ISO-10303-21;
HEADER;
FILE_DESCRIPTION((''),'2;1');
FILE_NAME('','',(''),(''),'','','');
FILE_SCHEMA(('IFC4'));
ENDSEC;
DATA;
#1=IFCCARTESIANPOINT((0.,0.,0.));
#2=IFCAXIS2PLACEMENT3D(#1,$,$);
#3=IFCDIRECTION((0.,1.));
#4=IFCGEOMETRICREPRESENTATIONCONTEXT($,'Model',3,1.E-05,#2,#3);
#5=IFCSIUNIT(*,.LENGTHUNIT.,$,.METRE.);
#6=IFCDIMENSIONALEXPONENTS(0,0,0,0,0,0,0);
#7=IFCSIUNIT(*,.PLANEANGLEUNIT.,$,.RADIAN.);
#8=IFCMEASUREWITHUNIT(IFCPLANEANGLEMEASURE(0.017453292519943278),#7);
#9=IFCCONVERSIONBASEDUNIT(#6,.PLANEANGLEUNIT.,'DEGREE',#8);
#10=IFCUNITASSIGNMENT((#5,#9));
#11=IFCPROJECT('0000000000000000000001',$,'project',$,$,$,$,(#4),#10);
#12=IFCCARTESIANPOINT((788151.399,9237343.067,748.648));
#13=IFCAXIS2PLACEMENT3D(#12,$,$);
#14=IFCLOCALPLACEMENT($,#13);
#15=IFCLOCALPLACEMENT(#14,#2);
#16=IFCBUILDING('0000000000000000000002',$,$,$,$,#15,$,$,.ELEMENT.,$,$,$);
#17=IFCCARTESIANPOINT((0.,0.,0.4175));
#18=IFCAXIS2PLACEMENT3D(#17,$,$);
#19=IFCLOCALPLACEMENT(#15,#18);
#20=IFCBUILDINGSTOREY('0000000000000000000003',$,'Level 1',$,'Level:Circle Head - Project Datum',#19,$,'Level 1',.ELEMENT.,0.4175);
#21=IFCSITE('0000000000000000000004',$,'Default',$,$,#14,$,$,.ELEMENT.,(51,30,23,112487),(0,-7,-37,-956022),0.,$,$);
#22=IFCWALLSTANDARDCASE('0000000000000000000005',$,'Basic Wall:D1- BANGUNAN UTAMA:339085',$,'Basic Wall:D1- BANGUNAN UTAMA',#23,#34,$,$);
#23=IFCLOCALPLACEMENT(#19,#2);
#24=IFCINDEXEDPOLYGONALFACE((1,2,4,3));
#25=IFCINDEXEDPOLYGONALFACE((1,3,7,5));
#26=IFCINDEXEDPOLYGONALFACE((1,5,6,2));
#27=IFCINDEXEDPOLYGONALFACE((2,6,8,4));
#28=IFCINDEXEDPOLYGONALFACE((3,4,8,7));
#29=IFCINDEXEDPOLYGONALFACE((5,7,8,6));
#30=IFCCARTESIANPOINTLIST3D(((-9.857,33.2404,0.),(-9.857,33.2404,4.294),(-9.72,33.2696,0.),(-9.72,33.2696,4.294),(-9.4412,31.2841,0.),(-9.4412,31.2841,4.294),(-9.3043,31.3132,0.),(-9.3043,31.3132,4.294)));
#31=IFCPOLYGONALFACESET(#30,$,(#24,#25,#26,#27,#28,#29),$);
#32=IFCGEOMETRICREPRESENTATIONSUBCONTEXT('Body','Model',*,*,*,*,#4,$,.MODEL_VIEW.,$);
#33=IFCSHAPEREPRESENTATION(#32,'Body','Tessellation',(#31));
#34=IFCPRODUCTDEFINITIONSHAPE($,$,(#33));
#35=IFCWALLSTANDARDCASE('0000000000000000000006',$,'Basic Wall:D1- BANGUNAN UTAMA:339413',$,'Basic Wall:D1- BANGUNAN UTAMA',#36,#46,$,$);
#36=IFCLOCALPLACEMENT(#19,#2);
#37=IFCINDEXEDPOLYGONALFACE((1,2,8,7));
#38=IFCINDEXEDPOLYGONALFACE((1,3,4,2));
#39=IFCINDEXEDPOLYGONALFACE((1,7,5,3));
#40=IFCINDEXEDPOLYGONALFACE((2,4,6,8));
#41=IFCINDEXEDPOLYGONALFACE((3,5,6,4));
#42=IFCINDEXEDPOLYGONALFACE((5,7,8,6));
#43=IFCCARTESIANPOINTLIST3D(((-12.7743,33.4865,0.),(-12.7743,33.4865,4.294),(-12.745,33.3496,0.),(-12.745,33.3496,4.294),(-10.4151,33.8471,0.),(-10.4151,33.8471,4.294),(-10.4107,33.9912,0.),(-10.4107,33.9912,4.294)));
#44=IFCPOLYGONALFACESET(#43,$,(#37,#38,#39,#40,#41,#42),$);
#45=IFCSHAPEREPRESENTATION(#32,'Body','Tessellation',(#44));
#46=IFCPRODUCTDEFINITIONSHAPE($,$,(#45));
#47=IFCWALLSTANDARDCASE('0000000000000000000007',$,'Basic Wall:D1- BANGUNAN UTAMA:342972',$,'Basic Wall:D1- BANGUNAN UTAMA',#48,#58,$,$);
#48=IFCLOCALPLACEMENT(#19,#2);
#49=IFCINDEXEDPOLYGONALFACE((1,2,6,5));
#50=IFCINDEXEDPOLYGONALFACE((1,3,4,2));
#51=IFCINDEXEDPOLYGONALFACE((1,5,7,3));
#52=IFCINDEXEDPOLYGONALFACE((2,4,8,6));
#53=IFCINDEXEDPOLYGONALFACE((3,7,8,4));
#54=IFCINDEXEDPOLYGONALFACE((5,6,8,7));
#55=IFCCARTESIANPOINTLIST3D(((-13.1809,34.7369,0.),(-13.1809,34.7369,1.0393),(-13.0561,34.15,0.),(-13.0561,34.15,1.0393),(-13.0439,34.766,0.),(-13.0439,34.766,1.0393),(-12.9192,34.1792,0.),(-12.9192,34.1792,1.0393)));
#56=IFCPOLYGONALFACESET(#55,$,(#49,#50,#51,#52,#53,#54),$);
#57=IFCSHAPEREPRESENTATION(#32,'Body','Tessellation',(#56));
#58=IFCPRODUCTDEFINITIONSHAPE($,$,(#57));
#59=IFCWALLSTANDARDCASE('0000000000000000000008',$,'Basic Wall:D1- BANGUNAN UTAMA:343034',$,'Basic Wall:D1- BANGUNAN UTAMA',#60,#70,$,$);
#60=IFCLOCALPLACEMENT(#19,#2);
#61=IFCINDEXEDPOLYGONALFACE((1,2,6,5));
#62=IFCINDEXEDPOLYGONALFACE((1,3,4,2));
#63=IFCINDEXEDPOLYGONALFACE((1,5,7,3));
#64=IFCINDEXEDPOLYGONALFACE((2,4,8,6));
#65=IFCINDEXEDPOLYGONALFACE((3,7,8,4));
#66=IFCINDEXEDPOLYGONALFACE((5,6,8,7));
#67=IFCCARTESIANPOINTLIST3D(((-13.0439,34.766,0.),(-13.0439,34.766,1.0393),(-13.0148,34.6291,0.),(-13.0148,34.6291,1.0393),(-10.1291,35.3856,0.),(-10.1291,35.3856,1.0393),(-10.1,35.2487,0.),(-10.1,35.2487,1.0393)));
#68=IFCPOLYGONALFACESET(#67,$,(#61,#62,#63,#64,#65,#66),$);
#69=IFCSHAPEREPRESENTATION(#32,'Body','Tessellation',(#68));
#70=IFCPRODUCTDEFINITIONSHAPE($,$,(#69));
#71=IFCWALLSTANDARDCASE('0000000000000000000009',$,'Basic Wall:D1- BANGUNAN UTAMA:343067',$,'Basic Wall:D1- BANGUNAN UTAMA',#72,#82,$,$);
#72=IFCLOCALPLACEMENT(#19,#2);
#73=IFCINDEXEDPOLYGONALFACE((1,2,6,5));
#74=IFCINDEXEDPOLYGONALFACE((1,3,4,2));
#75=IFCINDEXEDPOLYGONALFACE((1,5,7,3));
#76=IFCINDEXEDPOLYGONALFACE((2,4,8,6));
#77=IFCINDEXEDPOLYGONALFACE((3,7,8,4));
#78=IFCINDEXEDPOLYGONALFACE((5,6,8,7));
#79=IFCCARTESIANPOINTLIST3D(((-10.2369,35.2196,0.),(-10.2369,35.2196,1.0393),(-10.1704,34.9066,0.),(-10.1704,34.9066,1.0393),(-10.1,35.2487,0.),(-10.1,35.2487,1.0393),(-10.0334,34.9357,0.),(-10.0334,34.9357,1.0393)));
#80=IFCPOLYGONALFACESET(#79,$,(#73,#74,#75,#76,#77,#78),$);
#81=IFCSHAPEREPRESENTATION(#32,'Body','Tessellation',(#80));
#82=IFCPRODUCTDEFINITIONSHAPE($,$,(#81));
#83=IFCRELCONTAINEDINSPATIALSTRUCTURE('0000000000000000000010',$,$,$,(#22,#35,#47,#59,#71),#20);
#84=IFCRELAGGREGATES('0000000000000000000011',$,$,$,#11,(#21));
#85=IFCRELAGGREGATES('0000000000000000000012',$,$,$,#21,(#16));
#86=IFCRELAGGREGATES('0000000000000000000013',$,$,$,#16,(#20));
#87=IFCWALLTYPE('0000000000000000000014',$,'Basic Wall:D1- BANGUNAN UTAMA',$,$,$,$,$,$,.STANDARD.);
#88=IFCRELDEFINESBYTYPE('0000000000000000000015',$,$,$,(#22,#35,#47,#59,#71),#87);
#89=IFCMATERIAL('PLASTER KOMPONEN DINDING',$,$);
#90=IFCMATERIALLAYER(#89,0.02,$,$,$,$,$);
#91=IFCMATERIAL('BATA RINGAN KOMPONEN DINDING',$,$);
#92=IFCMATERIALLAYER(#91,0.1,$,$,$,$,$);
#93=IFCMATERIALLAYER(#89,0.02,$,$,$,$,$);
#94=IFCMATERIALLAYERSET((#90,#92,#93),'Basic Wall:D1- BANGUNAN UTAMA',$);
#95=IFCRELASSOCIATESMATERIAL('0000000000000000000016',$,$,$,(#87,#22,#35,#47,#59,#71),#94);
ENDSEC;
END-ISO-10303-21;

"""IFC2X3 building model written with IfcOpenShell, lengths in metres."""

from ifc_helpers import new_model, entity, si_unit, converted_unit, direction, frame, frame_2d, origin, place, context, subcontext, project, spatial, polyline, rectangle, outline, extrude, material, layer, layer_set, layer_usage, type_object, element, save


model = new_model("IFC2X3")

# Units and contexts
model_context = context("Model", 3, precision=1e-05, world=origin(), true_north=direction((0.0, 1.0)))
body_context = subcontext(model_context, "Body", "Model", "MODEL_VIEW")
ifc_project = project(units=[si_unit("LENGTHUNIT", "METRE"), converted_unit("PLANEANGLEUNIT", "DEGREE", entity("IfcPlaneAngleMeasure", 0.017453292519943278), si_unit("PLANEANGLEUNIT", "RADIAN"), dimensions=[0, 0, 0, 0, 0, 0, 0])], contexts=[model_context])

# Site, building, storey
site_placement = place(None, frame((788151.399, 9237343.067, 748.648)))
site = spatial("IfcSite", under=ifc_project, at=site_placement, Name="Default", CompositionType="ELEMENT", RefLatitude=(51, 30, 23, 112487), RefLongitude=(0, -7, -37, -956022), RefElevation=0.0)
building_placement = place(site_placement, origin())
building = spatial("IfcBuilding", under=site, at=building_placement, CompositionType="ELEMENT")
storey_placement = place(building_placement, frame((0.0, 0.0, 0.4175)))
storey = spatial("IfcBuildingStorey", under=building, at=storey_placement, Name="Level 1", ObjectType="Level:Circle Head - Project Datum", LongName="Level 1", CompositionType="ELEMENT", Elevation=0.4175)

# Walls
ifc_material_1 = material(Name="PLASTER KOMPONEN DINDING")
ifc_layer_1 = layer(ifc_material_1, 0.02)
ifc_material_2 = material(Name="BATA RINGAN KOMPONEN DINDING")
ifc_layer_2 = layer(ifc_material_2, 0.1)
ifc_layer_3 = layer(ifc_material_1, 0.02)
ifc_layer_set = layer_set([ifc_layer_1, ifc_layer_2, ifc_layer_3], Name="Basic Wall:D1- BANGUNAN UTAMA")
wall_type = type_object("IfcWallType", Name="Basic Wall:D1- BANGUNAN UTAMA", PredefinedType="STANDARD", material=ifc_layer_set)
ifc_layer_usage_1 = layer_usage(ifc_layer_set, "AXIS2", "NEGATIVE", 0.07)
wall_1_placement = place(storey_placement, frame((-9.7885, 33.255, 0.0), z_axis=(0.0, 0.0, 1.0), x_axis=(0.207863, -0.978158, 0.0)))
element("IfcWallStandardCase", 1, at=wall_1_placement, inside=storey, type_object=wall_type, material=ifc_layer_usage_1, Name="Basic Wall:D1- BANGUNAN UTAMA:339085", ObjectType="Basic Wall:D1- BANGUNAN UTAMA", context=body_context, shape_type="SweptSolid", body=[
    extrude(rectangle(XDim=2.0, YDim=0.14, at=frame_2d((1.0, 0.0), x_axis=(-1.0, 0.0))), origin(), (0.0, 0.0, 1.0), 4.294),
])
ifc_layer_usage_2 = layer_usage(ifc_layer_set, "AXIS2", "NEGATIVE", 0.07)
wall_2_placement = place(storey_placement, frame((-12.7597, 33.418, 0.0), z_axis=(0.0, 0.0, 1.0), x_axis=(0.977952, 0.208828, 0.0)))
element("IfcWallStandardCase", 2, at=wall_2_placement, inside=storey, type_object=wall_type, material=ifc_layer_usage_2, Name="Basic Wall:D1- BANGUNAN UTAMA:339413", ObjectType="Basic Wall:D1- BANGUNAN UTAMA", context=body_context, shape_type="SweptSolid", body=[
    extrude(outline(polyline([(2.3824, -0.07), (2.4169, 0.07), (0.0, 0.07), (0.0, -0.07), (2.3824, -0.07)])), origin(), (0.0, 0.0, 1.0), 4.294),
])
ifc_layer_usage_3 = layer_usage(ifc_layer_set, "AXIS2", "NEGATIVE", 0.07)
wall_3_placement = place(storey_placement, frame((-12.9877, 34.1646, 0.0), z_axis=(0.0, 0.0, 1.0), x_axis=(-0.207912, 0.978148, 0.0)))
element("IfcWallStandardCase", 3, at=wall_3_placement, inside=storey, type_object=wall_type, material=ifc_layer_usage_3, Name="Basic Wall:D1- BANGUNAN UTAMA:342972", ObjectType="Basic Wall:D1- BANGUNAN UTAMA", context=body_context, shape_type="SweptSolid", body=[
    extrude(rectangle(XDim=0.6, YDim=0.14, at=frame_2d((0.3, 0.0), x_axis=(-1.0, 0.0))), origin(), (0.0, 0.0, 1.0), 1.0393),
])
ifc_layer_usage_4 = layer_usage(ifc_layer_set, "AXIS2", "NEGATIVE", 0.07)
wall_4_placement = place(storey_placement, frame((-13.0294, 34.6976, 0.0), z_axis=(0.0, 0.0, 1.0), x_axis=(0.978148, 0.207912, 0.0)))
element("IfcWallStandardCase", 4, at=wall_4_placement, inside=storey, type_object=wall_type, material=ifc_layer_usage_4, Name="Basic Wall:D1- BANGUNAN UTAMA:343034", ObjectType="Basic Wall:D1- BANGUNAN UTAMA", context=body_context, shape_type="SweptSolid", body=[
    extrude(rectangle(XDim=2.98, YDim=0.14, at=frame_2d((1.49, 0.0), x_axis=(-1.0, 0.0))), origin(), (0.0, 0.0, 1.0), 1.0393),
])
ifc_layer_usage_5 = layer_usage(ifc_layer_set, "AXIS2", "NEGATIVE", 0.07)
wall_5_placement = place(storey_placement, frame((-10.1684, 35.2341, 0.0), z_axis=(0.0, 0.0, 1.0), x_axis=(0.207912, -0.978148, 0.0)))
element("IfcWallStandardCase", 5, at=wall_5_placement, inside=storey, type_object=wall_type, material=ifc_layer_usage_5, Name="Basic Wall:D1- BANGUNAN UTAMA:343067", ObjectType="Basic Wall:D1- BANGUNAN UTAMA", context=body_context, shape_type="SweptSolid", body=[
    extrude(rectangle(XDim=0.32, YDim=0.14, at=frame_2d((0.16, 0.0), x_axis=(-1.0, 0.0))), origin(), (0.0, 0.0, 1.0), 1.0393),
])

save(model, "model.ifc")
